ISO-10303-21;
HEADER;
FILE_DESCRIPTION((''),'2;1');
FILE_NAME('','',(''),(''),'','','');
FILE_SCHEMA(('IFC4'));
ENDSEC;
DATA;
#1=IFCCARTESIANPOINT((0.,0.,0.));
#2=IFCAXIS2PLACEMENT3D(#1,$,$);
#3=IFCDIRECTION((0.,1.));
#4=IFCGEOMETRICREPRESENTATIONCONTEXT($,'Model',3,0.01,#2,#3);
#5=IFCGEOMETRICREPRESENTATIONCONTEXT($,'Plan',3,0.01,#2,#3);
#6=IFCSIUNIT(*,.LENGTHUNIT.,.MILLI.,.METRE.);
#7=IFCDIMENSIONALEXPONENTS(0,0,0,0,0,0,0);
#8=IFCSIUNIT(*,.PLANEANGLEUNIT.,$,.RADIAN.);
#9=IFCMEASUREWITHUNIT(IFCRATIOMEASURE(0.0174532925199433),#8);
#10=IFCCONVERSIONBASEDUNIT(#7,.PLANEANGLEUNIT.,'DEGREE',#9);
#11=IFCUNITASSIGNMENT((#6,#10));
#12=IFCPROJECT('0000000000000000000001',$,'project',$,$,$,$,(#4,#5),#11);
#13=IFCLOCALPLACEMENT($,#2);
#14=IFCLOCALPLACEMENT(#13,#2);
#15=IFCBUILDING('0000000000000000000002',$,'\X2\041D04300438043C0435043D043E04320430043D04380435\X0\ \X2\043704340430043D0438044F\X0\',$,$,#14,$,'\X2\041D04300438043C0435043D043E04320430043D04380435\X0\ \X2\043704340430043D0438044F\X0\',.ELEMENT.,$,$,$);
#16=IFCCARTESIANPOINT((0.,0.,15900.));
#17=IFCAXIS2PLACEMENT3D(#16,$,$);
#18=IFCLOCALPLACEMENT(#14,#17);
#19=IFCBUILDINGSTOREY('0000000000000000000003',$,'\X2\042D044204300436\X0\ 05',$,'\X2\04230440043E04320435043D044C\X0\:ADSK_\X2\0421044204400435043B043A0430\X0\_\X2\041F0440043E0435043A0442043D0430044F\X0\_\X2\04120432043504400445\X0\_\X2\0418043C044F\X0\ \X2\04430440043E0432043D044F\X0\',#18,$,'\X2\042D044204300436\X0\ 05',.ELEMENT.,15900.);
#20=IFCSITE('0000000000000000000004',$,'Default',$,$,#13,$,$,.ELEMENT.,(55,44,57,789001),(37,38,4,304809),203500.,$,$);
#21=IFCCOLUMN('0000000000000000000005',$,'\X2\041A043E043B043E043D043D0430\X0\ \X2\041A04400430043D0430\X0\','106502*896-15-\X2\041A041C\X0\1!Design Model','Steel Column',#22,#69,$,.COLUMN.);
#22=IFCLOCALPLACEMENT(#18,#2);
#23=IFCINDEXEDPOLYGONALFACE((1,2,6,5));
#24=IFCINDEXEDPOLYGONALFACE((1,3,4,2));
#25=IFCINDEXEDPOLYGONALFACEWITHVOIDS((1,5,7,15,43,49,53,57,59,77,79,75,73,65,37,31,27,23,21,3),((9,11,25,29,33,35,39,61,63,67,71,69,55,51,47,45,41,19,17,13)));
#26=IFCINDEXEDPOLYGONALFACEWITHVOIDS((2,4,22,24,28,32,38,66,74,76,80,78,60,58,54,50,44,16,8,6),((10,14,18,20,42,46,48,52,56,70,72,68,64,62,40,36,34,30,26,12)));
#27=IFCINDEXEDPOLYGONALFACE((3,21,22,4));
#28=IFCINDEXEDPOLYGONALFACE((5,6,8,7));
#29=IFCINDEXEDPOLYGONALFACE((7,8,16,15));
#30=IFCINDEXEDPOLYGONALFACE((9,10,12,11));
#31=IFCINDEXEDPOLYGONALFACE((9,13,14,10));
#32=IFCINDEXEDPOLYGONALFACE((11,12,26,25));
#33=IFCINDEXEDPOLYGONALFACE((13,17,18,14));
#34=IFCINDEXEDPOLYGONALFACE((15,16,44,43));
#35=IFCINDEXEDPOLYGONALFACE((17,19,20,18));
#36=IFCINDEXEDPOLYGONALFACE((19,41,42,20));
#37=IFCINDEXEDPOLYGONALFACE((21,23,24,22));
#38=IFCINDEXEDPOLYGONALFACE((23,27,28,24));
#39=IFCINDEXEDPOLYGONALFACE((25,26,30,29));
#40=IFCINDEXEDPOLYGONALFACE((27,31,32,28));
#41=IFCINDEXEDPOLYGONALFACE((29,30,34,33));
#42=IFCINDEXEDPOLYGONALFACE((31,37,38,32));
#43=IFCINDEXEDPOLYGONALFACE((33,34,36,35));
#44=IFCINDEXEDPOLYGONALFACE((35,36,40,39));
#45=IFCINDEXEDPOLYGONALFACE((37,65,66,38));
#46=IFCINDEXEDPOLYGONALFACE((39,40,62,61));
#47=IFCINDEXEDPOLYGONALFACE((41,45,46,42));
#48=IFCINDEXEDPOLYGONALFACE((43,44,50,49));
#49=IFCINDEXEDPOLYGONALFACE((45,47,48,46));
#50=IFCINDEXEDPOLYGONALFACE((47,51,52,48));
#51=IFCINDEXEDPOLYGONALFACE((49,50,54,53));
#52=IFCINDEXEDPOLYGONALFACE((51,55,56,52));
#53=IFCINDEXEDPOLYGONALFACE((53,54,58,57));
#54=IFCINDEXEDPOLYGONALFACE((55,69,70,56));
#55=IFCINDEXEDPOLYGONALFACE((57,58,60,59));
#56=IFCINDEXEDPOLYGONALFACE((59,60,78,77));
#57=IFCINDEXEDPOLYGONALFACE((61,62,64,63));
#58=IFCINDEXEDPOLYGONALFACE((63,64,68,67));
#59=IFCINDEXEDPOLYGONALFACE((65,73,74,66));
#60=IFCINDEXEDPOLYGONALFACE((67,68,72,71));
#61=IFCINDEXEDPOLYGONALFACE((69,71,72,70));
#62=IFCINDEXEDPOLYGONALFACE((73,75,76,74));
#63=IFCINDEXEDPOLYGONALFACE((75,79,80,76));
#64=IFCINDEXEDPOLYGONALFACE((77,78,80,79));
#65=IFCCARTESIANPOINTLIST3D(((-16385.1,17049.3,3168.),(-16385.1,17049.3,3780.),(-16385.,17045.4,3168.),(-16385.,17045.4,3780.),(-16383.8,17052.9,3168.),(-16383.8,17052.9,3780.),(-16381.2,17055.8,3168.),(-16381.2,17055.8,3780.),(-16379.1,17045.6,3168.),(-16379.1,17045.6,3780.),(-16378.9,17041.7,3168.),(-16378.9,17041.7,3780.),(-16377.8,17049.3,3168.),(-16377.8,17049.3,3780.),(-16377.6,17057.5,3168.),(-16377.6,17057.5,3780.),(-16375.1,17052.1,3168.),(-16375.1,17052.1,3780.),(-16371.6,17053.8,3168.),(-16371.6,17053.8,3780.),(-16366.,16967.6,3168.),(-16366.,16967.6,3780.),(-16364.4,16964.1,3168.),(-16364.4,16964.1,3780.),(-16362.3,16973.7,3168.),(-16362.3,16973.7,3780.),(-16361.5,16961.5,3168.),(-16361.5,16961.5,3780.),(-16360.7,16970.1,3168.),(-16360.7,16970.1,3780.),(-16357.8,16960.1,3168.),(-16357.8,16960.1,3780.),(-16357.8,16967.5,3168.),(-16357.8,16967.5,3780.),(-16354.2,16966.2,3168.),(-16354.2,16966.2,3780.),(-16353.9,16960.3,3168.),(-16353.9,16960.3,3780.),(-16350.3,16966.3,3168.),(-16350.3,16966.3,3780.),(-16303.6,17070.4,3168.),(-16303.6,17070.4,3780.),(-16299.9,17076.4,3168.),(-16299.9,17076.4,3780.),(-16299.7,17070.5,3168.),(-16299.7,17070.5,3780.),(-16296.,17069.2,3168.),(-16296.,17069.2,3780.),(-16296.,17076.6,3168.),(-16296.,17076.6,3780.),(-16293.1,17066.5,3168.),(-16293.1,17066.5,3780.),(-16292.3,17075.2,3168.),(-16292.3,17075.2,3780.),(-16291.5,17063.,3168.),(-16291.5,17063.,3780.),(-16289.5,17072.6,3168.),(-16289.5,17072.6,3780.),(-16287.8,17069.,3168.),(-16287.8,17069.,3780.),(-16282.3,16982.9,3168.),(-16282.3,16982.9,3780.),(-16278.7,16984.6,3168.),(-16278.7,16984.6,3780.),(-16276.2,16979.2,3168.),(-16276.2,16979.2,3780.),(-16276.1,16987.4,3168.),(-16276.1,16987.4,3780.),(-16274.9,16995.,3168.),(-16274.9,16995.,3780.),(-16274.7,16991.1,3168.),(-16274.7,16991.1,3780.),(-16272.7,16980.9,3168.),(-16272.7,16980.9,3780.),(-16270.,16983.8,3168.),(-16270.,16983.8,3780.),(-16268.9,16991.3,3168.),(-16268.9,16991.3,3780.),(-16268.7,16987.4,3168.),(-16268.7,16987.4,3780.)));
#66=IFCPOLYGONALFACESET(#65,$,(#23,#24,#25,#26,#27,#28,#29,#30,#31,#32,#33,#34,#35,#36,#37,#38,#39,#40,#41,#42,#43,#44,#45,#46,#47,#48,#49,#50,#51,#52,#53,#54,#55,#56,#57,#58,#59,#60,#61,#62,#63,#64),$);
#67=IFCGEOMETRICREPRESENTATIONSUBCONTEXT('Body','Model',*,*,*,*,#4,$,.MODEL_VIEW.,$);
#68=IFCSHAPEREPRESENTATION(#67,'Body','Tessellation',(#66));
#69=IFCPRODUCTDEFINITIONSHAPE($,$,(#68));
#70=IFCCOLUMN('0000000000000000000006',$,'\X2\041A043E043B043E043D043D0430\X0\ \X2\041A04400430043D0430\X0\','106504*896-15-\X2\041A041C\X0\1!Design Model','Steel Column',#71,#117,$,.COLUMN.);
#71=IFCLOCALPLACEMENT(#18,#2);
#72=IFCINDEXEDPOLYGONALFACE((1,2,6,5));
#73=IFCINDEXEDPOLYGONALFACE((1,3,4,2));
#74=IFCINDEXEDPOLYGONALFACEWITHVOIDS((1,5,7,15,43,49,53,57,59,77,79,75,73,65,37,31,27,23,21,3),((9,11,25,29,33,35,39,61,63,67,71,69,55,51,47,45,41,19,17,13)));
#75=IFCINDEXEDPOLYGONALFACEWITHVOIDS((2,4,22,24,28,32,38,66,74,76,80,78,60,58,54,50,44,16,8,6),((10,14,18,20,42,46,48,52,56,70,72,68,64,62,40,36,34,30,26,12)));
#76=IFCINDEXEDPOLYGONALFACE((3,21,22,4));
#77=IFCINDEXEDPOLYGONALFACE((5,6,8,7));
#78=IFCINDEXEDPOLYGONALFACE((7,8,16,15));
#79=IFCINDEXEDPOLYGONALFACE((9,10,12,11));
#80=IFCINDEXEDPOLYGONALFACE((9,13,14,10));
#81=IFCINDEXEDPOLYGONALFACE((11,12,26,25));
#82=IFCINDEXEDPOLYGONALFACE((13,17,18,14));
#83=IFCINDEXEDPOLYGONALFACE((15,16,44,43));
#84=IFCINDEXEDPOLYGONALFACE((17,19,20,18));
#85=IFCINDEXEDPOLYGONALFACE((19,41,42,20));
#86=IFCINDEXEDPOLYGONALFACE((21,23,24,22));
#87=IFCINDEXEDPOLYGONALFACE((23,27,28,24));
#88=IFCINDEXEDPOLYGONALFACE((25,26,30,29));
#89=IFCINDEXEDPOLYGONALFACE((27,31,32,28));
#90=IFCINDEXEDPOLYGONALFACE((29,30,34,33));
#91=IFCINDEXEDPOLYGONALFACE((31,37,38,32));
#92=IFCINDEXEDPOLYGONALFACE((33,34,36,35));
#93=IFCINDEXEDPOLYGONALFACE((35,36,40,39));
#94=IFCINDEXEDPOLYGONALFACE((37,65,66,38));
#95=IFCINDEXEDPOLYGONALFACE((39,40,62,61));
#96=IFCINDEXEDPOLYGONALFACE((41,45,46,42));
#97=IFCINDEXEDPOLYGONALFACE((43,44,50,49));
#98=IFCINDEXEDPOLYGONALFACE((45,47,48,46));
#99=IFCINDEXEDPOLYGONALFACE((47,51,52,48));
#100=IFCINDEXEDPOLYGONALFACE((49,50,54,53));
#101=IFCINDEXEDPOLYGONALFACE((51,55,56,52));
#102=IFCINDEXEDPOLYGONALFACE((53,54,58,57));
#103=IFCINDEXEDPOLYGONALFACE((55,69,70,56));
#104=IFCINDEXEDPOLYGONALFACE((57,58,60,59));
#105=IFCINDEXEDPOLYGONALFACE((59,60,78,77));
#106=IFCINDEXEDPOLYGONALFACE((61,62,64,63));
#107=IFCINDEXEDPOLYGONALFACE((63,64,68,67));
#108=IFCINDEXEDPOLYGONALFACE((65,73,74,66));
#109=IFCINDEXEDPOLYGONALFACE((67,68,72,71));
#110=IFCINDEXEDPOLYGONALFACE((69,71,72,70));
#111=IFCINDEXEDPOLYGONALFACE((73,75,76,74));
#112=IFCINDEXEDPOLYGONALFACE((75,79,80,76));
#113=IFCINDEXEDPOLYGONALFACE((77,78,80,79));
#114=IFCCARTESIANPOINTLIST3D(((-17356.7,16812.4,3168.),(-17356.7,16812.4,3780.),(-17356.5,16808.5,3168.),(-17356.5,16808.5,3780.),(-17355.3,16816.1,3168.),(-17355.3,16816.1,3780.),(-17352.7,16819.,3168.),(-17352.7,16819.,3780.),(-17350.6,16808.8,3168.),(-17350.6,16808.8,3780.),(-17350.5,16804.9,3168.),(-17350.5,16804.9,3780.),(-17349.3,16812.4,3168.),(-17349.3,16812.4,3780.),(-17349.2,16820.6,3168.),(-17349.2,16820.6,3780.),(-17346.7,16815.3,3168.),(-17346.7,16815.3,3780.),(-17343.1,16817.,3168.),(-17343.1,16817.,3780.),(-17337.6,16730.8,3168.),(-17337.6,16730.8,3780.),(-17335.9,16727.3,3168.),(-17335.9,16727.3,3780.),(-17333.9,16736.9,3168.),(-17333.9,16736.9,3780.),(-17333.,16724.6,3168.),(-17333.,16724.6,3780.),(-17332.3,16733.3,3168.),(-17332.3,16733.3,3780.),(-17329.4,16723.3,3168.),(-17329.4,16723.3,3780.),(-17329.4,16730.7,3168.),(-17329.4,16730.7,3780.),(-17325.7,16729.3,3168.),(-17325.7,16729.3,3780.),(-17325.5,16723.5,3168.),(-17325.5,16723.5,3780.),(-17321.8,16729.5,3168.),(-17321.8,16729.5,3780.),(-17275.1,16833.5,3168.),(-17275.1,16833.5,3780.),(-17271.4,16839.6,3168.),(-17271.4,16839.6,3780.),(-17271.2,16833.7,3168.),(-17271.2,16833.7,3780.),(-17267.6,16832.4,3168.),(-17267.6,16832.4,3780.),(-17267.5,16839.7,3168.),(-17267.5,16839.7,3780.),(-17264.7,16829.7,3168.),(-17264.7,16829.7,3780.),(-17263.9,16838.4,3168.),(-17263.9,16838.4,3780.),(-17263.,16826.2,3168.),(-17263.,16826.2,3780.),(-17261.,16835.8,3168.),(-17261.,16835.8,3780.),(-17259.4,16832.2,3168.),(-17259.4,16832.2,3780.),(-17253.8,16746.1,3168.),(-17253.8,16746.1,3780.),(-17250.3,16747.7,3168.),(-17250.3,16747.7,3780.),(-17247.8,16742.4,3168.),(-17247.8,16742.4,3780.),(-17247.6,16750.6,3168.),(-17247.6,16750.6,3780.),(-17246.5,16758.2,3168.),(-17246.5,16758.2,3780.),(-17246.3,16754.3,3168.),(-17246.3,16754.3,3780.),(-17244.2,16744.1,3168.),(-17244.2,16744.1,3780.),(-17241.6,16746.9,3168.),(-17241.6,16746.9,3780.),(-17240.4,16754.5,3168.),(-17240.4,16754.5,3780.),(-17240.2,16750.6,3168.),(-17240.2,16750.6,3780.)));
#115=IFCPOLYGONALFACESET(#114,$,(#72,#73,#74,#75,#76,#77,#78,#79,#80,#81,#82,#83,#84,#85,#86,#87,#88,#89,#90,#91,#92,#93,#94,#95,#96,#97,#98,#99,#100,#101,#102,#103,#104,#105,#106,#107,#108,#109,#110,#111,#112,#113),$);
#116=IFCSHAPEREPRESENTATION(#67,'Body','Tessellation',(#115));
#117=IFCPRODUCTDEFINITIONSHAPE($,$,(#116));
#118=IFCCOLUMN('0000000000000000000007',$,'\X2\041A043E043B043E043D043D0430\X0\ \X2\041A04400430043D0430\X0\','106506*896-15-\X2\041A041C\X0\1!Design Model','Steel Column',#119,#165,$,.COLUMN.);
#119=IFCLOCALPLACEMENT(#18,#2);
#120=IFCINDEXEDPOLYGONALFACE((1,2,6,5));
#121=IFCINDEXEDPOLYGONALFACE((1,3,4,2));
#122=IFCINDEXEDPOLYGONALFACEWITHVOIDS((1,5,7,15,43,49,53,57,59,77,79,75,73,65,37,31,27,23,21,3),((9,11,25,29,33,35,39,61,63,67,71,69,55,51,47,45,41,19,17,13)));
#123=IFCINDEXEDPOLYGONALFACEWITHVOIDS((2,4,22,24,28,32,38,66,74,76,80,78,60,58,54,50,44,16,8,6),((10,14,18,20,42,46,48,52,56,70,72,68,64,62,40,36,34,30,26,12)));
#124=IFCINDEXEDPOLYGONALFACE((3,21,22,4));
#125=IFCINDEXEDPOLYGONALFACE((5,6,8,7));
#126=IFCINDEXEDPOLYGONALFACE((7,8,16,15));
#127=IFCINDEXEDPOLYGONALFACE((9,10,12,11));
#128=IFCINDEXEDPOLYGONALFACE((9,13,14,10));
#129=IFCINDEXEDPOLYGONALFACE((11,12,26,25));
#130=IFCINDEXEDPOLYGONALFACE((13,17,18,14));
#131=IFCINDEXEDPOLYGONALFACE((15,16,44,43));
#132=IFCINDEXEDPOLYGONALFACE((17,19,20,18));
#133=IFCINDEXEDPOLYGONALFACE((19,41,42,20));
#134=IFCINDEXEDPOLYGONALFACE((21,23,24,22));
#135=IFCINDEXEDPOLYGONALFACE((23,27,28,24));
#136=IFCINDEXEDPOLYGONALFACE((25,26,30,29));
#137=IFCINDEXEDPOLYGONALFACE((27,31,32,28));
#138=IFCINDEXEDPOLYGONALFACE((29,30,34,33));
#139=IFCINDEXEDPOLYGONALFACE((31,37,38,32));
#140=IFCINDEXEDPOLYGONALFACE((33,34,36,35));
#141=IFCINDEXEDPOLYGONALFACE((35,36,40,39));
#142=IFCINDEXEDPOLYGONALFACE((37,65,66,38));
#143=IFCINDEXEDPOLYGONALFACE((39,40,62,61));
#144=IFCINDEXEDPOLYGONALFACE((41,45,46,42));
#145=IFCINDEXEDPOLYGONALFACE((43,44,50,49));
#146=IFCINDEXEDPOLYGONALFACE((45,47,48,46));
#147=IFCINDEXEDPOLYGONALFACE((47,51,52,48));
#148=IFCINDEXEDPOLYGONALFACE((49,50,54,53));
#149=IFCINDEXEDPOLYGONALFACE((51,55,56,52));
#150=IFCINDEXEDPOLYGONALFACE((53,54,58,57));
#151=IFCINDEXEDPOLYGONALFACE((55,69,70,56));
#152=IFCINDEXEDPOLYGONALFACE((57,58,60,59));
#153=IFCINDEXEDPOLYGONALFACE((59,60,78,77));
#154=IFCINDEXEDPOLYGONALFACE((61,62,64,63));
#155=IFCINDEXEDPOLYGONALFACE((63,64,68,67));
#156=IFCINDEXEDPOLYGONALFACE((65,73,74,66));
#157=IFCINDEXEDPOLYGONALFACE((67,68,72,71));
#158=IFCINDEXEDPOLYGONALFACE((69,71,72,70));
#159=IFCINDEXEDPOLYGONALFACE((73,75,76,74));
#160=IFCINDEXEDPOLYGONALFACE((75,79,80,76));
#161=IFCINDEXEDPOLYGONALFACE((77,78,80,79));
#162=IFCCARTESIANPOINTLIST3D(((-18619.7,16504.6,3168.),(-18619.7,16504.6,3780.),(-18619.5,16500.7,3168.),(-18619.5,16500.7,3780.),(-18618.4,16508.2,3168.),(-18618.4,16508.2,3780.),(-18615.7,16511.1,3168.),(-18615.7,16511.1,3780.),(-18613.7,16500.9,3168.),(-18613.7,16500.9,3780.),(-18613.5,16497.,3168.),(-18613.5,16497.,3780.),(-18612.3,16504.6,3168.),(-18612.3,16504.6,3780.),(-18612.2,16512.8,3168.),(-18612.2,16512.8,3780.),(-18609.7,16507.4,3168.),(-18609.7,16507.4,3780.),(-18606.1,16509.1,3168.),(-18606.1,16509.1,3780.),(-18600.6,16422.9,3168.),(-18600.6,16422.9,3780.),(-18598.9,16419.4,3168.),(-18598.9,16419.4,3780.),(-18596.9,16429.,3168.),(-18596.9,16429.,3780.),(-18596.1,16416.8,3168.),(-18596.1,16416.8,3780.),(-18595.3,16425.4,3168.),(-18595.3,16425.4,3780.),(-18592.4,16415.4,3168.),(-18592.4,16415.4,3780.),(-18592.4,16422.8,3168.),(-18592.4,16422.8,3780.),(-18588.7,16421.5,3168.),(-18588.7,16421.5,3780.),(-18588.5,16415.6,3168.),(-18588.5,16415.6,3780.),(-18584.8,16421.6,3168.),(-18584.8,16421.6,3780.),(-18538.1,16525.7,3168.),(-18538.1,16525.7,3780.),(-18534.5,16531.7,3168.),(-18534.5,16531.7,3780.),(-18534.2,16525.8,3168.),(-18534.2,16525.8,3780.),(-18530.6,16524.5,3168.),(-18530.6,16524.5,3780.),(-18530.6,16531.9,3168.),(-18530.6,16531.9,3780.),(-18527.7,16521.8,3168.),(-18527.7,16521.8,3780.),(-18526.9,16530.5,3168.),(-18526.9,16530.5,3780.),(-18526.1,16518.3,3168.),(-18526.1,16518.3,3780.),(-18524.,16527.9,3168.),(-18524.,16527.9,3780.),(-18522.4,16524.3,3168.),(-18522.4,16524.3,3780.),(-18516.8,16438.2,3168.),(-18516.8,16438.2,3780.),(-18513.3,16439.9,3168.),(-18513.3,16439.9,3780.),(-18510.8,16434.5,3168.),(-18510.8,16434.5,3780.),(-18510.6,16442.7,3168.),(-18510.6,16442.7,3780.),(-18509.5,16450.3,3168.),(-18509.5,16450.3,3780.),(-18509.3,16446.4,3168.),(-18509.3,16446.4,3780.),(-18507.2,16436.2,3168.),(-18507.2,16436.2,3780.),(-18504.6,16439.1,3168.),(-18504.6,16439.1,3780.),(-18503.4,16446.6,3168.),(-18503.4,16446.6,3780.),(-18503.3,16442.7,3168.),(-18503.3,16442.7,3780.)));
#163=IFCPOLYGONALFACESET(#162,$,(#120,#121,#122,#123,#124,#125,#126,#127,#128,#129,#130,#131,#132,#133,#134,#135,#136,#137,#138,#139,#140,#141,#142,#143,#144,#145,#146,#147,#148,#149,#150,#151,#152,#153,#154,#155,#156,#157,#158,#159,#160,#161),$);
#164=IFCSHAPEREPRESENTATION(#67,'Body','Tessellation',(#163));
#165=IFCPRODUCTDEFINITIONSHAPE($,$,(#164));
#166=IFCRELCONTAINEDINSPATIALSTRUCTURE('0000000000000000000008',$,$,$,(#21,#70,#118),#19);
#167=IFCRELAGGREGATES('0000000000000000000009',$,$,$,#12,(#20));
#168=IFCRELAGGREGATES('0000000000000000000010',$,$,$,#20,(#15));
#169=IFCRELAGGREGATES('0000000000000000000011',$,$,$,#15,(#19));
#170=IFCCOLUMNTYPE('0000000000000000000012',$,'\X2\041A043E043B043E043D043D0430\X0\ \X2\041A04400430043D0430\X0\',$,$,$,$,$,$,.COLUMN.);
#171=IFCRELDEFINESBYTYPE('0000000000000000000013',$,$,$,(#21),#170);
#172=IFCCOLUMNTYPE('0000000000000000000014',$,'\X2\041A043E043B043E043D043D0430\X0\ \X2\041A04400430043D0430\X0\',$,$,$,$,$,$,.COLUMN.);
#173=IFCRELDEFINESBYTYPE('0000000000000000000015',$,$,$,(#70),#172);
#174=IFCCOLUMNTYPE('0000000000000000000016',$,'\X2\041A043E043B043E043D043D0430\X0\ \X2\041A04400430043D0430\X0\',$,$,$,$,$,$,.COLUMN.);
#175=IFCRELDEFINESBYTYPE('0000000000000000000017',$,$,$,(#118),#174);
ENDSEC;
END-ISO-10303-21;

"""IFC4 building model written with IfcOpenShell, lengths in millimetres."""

from ifc_helpers import new_model, entity, si_unit, converted_unit, direction, frame, origin, place, context, subcontext, project, spatial, indexed_curve, outline, extrude, type_object, element, save


model = new_model("IFC4")

# Units and contexts
model_context = context("Model", 3, precision=0.01, world=origin(), true_north=direction((0.0, 1.0)))
plan_context = context("Plan", 3, precision=0.01, world=origin(), true_north=direction((0.0, 1.0)))
body_context = subcontext(model_context, "Body", "Model", "MODEL_VIEW")
ifc_project = project(units=[si_unit("LENGTHUNIT", "METRE", prefix="MILLI"), converted_unit("PLANEANGLEUNIT", "DEGREE", entity("IfcRatioMeasure", 0.0174532925199433), si_unit("PLANEANGLEUNIT", "RADIAN"), dimensions=[0, 0, 0, 0, 0, 0, 0])], contexts=[model_context, plan_context])

# Site, building, storey
site_placement = place(None, origin())
site = spatial("IfcSite", under=ifc_project, at=site_placement, Name="Default", CompositionType="ELEMENT", RefLatitude=(55, 44, 57, 789001), RefLongitude=(37, 38, 4, 304809), RefElevation=203500.0)
building_placement = place(site_placement, origin())
building = spatial("IfcBuilding", under=site, at=building_placement, Name="Наименование здания", LongName="Наименование здания", CompositionType="ELEMENT")
storey_placement = place(building_placement, frame((0.0, 0.0, 15900.0)))
storey = spatial("IfcBuildingStorey", under=building, at=storey_placement, Name="Этаж 05", ObjectType="Уровень:ADSK_Стрелка_Проектная_Вверх_Имя уровня", LongName="Этаж 05", CompositionType="ELEMENT", Elevation=15900.0)

# Columns
column_type_1 = type_object("IfcColumnType", Name="Колонна Крана", PredefinedType="COLUMN")
column_1_placement = place(storey_placement, origin())
element("IfcColumn", 1, at=column_1_placement, inside=storey, type_object=column_type_1, Name="Колонна Крана", Description="106502*896-15-КМ1!Design Model", ObjectType="Steel Column", PredefinedType="COLUMN", context=body_context, shape_type="SweptSolid", body=[
    extrude(outline(indexed_curve([(29.5, -56.8), (33.4, -56.8), (37.0, -55.3), (39.7, -52.6), (41.2, -49.0), (56.8, 29.5), (56.8, 33.4), (55.3, 37.0), (52.6, 39.7), (49.0, 41.2), (-29.5, 56.8), (-33.4, 56.8), (-37.0, 55.3), (-39.7, 52.6), (-41.2, 49.0), (-56.8, -29.5), (-56.8, -33.4), (-55.3, -37.0), (-52.6, -39.7), (-49.0, -41.2), (29.5, -56.8)], self_intersect=False), holes=[indexed_curve([(-43.1, -37.3), (-46.7, -35.8), (-49.5, -33.1), (-51.0, -29.5), (-51.0, -25.5), (-37.3, 43.1), (-35.8, 46.7), (-33.1, 49.5), (-29.5, 51.0), (-25.5, 51.0), (43.1, 37.3), (46.7, 35.8), (49.5, 33.1), (51.0, 29.5), (51.0, 25.5), (37.3, -43.1), (35.8, -46.7), (33.1, -49.5), (29.5, -51.0), (25.5, -51.0), (-43.1, -37.3)], self_intersect=False)]), frame((-16326.9, 17018.3, 3168.0), z_axis=(0.0, 0.0, 1.0), x_axis=(0.906681, 0.421816, 0.0)), (0.0, 0.0, 1.0), 612.0),
])
column_type_2 = type_object("IfcColumnType", Name="Колонна Крана", PredefinedType="COLUMN")
column_2_placement = place(storey_placement, origin())
element("IfcColumn", 2, at=column_2_placement, inside=storey, type_object=column_type_2, Name="Колонна Крана", Description="106504*896-15-КМ1!Design Model", ObjectType="Steel Column", PredefinedType="COLUMN", context=body_context, shape_type="SweptSolid", body=[
    extrude(outline(indexed_curve([(29.5, -56.8), (33.4, -56.8), (37.0, -55.3), (39.7, -52.6), (41.2, -49.0), (56.8, 29.5), (56.8, 33.4), (55.3, 37.0), (52.6, 39.7), (49.0, 41.2), (-29.5, 56.8), (-33.4, 56.8), (-37.0, 55.3), (-39.7, 52.6), (-41.2, 49.0), (-56.8, -29.5), (-56.8, -33.4), (-55.3, -37.0), (-52.6, -39.7), (-49.0, -41.2), (29.5, -56.8)], self_intersect=False), holes=[indexed_curve([(-43.1, -37.3), (-46.7, -35.8), (-49.5, -33.1), (-51.0, -29.5), (-51.0, -25.5), (-37.3, 43.1), (-35.8, 46.7), (-33.1, 49.5), (-29.5, 51.0), (-25.5, 51.0), (43.1, 37.3), (46.7, 35.8), (49.5, 33.1), (51.0, 29.5), (51.0, 25.5), (37.3, -43.1), (35.8, -46.7), (33.1, -49.5), (29.5, -51.0), (25.5, -51.0), (-43.1, -37.3)], self_intersect=False)]), frame((-17298.5, 16781.5, 3168.0), z_axis=(0.0, 0.0, 1.0), x_axis=(0.906681, 0.421816, 0.0)), (0.0, 0.0, 1.0), 612.0),
])
column_type_3 = type_object("IfcColumnType", Name="Колонна Крана", PredefinedType="COLUMN")
column_3_placement = place(storey_placement, origin())
element("IfcColumn", 3, at=column_3_placement, inside=storey, type_object=column_type_3, Name="Колонна Крана", Description="106506*896-15-КМ1!Design Model", ObjectType="Steel Column", PredefinedType="COLUMN", context=body_context, shape_type="SweptSolid", body=[
    extrude(outline(indexed_curve([(29.5, -56.8), (33.4, -56.8), (37.0, -55.3), (39.7, -52.6), (41.2, -49.0), (56.8, 29.5), (56.8, 33.4), (55.3, 37.0), (52.6, 39.7), (49.0, 41.2), (-29.5, 56.8), (-33.4, 56.8), (-37.0, 55.3), (-39.7, 52.6), (-41.2, 49.0), (-56.8, -29.5), (-56.8, -33.4), (-55.3, -37.0), (-52.6, -39.7), (-49.0, -41.2), (29.5, -56.8)], self_intersect=False), holes=[indexed_curve([(-43.1, -37.3), (-46.7, -35.8), (-49.5, -33.1), (-51.0, -29.5), (-51.0, -25.5), (-37.3, 43.1), (-35.8, 46.7), (-33.1, 49.5), (-29.5, 51.0), (-25.5, 51.0), (43.1, 37.3), (46.7, 35.8), (49.5, 33.1), (51.0, 29.5), (51.0, 25.5), (37.3, -43.1), (35.8, -46.7), (33.1, -49.5), (29.5, -51.0), (25.5, -51.0), (-43.1, -37.3)], self_intersect=False)]), frame((-18561.5, 16473.6, 3168.0), z_axis=(0.0, 0.0, 1.0), x_axis=(0.906681, 0.421816, 0.0)), (0.0, 0.0, 1.0), 612.0),
])

save(model, "model.ifc")
